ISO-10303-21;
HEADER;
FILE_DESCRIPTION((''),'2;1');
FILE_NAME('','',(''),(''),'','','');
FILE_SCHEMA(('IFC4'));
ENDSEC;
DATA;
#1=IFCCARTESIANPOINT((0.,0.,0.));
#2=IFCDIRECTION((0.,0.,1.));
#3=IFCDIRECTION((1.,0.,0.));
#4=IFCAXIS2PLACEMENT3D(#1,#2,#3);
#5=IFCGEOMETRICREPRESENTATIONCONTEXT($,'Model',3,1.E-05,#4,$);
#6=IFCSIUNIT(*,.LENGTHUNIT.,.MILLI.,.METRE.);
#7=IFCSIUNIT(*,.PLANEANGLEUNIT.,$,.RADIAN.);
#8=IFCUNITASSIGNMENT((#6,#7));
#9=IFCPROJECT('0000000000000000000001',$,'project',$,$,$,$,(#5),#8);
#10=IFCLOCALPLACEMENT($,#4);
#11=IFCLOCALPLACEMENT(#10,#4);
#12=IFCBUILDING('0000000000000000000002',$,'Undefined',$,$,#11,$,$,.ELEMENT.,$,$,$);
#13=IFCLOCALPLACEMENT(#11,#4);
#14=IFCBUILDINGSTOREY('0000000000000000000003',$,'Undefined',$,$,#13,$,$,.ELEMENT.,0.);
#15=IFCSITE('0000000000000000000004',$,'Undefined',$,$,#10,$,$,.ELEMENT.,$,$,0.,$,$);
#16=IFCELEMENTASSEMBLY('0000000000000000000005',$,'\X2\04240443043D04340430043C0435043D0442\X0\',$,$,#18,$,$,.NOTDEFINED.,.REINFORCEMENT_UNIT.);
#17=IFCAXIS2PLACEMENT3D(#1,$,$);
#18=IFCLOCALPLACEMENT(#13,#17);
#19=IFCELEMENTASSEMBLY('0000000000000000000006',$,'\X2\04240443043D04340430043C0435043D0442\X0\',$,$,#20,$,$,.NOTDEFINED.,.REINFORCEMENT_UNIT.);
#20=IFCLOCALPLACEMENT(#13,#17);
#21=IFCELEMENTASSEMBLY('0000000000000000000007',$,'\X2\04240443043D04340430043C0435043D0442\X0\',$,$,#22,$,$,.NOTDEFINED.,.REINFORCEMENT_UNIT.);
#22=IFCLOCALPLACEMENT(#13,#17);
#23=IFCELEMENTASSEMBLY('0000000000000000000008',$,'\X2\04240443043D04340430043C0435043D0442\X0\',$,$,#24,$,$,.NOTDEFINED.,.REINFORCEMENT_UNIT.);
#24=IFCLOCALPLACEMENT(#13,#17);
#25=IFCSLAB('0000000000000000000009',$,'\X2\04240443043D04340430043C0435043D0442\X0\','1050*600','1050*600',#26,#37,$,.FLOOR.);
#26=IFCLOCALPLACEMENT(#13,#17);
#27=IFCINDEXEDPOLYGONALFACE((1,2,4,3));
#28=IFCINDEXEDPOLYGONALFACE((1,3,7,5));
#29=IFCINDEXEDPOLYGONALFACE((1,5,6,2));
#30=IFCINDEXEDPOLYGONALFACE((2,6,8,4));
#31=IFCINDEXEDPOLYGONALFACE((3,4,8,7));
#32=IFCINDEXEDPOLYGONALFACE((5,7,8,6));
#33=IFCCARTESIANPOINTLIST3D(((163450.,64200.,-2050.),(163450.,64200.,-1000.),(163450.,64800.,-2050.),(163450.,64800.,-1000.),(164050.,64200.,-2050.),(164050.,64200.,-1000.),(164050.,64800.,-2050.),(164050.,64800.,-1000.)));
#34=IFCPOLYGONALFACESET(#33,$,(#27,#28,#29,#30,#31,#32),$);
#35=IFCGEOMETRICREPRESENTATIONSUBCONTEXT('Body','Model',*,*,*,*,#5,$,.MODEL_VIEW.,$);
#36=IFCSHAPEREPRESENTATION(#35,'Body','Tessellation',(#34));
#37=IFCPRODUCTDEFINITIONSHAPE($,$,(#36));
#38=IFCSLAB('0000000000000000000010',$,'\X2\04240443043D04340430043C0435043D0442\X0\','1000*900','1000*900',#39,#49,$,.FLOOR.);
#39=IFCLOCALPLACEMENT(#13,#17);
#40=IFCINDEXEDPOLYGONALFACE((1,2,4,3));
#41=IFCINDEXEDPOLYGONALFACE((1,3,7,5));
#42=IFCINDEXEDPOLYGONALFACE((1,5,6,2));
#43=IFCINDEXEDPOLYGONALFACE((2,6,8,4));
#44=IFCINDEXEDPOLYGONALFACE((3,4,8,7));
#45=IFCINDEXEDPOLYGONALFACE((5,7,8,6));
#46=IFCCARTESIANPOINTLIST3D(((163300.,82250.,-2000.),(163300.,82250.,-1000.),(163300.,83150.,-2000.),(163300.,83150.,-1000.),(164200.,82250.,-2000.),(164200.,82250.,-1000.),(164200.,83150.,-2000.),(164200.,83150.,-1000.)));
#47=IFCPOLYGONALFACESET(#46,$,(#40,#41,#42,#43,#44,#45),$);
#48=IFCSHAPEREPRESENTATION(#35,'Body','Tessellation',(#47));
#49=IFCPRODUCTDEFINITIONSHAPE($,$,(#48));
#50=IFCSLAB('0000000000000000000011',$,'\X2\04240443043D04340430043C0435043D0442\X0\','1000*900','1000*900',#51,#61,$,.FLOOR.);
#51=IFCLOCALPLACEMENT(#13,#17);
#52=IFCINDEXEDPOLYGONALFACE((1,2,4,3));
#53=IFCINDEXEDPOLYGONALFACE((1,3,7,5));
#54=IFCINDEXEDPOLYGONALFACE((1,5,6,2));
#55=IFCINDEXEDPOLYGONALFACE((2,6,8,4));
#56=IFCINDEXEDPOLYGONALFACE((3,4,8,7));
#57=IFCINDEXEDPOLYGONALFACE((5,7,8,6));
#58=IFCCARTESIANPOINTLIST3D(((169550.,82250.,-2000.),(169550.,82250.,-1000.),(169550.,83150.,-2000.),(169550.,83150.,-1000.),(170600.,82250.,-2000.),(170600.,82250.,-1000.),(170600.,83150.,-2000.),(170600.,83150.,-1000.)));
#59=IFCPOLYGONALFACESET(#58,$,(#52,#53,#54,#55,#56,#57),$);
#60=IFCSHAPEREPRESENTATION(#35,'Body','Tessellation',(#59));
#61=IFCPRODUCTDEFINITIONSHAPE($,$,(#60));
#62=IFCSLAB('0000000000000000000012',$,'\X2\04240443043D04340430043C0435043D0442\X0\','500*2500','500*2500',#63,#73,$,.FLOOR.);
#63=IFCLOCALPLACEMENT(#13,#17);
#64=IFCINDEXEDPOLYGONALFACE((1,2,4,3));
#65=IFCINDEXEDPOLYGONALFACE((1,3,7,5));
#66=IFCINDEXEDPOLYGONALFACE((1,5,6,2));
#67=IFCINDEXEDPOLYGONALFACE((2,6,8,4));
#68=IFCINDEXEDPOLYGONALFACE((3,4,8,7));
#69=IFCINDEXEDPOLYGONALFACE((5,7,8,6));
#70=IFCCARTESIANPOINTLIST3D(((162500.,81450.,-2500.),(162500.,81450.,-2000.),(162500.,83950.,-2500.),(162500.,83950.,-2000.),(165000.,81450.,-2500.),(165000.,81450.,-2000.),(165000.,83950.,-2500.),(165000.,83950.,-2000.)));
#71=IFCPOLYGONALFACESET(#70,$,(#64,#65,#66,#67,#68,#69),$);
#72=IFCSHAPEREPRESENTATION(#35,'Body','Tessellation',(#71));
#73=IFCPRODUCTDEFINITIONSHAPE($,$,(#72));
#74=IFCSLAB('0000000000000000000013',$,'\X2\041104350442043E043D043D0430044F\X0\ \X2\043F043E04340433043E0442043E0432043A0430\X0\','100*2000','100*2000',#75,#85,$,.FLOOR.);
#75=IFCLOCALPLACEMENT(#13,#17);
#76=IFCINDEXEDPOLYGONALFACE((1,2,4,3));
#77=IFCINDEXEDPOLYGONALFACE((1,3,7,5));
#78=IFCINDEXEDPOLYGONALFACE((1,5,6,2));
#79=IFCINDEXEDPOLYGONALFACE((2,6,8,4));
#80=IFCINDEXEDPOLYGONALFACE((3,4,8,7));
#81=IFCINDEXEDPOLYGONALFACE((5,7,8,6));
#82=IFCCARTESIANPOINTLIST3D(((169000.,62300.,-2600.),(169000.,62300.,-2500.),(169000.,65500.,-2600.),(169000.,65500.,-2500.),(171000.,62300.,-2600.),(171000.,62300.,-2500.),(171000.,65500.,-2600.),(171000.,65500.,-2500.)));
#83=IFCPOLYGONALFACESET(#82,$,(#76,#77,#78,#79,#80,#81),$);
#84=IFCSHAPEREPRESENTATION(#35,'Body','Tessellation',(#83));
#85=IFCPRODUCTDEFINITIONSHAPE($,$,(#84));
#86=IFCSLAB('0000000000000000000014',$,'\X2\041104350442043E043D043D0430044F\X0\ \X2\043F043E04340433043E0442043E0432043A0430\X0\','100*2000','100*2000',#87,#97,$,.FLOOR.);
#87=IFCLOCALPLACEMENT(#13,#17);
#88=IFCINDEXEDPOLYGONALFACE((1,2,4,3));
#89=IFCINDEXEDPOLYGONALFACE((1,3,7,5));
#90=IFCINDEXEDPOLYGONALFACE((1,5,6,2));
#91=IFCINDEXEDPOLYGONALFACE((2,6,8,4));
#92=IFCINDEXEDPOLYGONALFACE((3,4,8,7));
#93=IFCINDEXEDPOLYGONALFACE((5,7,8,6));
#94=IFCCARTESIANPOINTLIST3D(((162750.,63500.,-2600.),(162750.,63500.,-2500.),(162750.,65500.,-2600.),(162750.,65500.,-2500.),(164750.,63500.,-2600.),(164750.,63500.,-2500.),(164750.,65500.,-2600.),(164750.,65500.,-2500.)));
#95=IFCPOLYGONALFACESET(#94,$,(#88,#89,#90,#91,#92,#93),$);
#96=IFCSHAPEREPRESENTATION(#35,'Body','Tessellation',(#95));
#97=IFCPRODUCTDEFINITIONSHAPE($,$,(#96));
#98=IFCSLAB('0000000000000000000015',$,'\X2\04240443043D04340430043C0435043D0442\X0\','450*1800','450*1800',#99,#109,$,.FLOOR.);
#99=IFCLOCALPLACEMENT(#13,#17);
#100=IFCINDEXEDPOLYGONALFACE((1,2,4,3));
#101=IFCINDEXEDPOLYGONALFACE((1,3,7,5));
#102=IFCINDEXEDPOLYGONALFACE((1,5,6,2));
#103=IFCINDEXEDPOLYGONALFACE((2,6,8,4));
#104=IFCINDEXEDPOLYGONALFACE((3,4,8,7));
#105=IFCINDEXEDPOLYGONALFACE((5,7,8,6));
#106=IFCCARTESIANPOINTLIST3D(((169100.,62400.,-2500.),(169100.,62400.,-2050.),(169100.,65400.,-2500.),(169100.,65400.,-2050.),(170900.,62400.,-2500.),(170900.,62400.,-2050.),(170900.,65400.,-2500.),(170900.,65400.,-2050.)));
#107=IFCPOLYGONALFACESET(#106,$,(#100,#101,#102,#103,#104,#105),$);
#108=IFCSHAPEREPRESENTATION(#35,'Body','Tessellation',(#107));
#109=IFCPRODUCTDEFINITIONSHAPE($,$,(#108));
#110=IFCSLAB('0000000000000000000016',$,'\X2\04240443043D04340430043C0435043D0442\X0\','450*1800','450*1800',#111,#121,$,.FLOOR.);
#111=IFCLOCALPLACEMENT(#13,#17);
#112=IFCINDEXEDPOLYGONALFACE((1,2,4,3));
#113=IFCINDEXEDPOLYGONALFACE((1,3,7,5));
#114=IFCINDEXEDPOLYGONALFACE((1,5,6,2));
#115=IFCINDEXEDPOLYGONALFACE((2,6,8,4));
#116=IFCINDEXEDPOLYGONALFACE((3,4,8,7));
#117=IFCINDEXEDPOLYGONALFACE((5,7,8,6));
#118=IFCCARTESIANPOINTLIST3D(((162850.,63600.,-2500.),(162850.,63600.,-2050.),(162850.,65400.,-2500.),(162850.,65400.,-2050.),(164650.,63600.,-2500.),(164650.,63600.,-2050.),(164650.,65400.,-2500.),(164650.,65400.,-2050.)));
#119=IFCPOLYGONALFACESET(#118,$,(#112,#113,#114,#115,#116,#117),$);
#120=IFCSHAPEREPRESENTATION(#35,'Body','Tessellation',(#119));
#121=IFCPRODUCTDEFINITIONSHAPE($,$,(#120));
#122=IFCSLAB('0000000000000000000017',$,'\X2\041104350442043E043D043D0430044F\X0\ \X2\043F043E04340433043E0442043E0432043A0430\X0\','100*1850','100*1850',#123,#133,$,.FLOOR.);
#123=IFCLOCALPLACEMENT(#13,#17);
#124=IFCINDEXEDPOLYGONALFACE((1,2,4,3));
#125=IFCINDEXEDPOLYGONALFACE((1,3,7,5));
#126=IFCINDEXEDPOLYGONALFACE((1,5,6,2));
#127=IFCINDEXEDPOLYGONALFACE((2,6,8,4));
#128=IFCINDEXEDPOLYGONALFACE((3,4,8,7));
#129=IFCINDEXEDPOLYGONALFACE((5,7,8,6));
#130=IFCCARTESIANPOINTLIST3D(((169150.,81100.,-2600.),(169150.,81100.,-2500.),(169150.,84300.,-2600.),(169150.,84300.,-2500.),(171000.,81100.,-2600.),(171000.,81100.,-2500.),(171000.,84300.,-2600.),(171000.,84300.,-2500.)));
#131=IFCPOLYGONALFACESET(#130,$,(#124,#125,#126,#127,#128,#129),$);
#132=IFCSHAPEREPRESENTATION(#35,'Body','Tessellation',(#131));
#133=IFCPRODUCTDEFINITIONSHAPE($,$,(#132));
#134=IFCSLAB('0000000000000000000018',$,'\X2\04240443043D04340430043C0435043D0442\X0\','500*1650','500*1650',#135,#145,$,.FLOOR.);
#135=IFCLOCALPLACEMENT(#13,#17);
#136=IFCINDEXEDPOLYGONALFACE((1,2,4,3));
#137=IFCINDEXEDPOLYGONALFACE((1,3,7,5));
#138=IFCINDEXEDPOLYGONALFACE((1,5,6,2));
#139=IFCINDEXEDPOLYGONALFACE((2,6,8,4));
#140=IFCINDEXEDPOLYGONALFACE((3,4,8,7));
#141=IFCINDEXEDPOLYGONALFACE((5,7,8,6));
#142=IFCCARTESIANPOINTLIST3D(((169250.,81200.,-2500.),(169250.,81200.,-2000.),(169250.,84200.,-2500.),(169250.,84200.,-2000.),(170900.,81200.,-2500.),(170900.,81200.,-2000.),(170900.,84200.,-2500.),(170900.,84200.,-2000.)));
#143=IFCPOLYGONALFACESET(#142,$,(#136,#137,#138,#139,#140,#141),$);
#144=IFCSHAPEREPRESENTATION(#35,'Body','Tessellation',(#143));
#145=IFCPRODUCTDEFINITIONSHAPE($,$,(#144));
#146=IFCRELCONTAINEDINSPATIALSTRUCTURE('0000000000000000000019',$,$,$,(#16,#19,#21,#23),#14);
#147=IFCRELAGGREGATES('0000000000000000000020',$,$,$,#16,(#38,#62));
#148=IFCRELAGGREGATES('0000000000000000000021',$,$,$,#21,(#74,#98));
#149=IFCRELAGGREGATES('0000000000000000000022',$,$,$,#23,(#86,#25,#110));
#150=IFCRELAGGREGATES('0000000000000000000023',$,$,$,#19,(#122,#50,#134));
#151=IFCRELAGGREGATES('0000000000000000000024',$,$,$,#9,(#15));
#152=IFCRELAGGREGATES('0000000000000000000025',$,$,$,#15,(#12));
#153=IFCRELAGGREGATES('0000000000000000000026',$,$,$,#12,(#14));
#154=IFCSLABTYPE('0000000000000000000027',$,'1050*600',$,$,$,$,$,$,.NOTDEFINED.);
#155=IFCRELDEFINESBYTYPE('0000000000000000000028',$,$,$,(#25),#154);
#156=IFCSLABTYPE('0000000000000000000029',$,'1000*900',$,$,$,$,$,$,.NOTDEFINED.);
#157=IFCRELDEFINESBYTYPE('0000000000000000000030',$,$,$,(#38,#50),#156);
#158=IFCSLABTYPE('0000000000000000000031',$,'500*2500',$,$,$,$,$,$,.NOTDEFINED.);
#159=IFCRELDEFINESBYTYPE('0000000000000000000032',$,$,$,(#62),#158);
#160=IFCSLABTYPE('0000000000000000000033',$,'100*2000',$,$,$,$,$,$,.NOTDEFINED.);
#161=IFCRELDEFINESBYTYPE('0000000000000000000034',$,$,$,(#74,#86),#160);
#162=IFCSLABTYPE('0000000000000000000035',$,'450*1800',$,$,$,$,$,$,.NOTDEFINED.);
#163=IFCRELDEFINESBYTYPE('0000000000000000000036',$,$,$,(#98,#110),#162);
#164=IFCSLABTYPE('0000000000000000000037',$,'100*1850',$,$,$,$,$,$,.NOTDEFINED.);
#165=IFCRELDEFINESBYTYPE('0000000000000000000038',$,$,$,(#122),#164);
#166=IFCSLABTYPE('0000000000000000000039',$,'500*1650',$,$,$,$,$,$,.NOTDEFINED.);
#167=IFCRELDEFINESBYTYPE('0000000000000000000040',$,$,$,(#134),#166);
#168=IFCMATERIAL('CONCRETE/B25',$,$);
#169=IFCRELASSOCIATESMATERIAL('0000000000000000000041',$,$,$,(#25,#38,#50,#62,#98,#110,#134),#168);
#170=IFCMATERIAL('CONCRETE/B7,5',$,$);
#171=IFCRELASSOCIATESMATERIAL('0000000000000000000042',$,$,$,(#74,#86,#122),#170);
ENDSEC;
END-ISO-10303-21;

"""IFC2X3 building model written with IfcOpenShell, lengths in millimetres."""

from ifc_helpers import new_model, si_unit, frame, origin_with_axes, place, context, subcontext, project, spatial, polyline, outline, extrude, material, type_object, element, aggregate, save


model = new_model("IFC2X3")

# Units and contexts
model_context = context("Model", 3, precision=1e-05, world=origin_with_axes())
body_context = subcontext(model_context, "Body", "Model", "MODEL_VIEW")
ifc_project = project(units=[si_unit("LENGTHUNIT", "METRE", prefix="MILLI"), si_unit("PLANEANGLEUNIT", "RADIAN")], contexts=[model_context])

# Site, building, storey
site_placement = place(None, origin_with_axes())
site = spatial("IfcSite", under=ifc_project, at=site_placement, Name="Undefined", CompositionType="ELEMENT", RefElevation=0.0)
building_placement = place(site_placement, origin_with_axes())
building = spatial("IfcBuilding", under=site, at=building_placement, Name="Undefined", CompositionType="ELEMENT")
storey_placement = place(building_placement, origin_with_axes())
storey = spatial("IfcBuildingStorey", under=building, at=storey_placement, Name="Undefined", CompositionType="ELEMENT", Elevation=0.0)

# Element assemblies
assembly_1_placement = place(storey_placement, origin_with_axes())
assembly_1 = element("IfcElementAssembly", 1, at=assembly_1_placement, inside=storey, Name="Фундамент", AssemblyPlace="NOTDEFINED", PredefinedType="REINFORCEMENT_UNIT")
ifc_material_1 = material(Name="CONCRETE/B25")
assembly_2_placement = place(storey_placement, origin_with_axes())
assembly_2 = element("IfcElementAssembly", 2, at=assembly_2_placement, inside=storey, Name="Фундамент", AssemblyPlace="NOTDEFINED", PredefinedType="REINFORCEMENT_UNIT")

# Shared definitions
ifc_material_2 = material(Name="CONCRETE/B7,5")

# Element assemblies, slab
assembly_3_placement = place(storey_placement, origin_with_axes())
assembly_3 = element("IfcElementAssembly", 3, at=assembly_3_placement, inside=storey, Name="Фундамент", AssemblyPlace="NOTDEFINED", PredefinedType="REINFORCEMENT_UNIT")
slab_type_1 = type_object("IfcSlabType", Name="1050*600", PredefinedType="NOTDEFINED")
assembly_4_placement = place(storey_placement, origin_with_axes())
assembly_4 = element("IfcElementAssembly", 4, at=assembly_4_placement, inside=storey, Name="Фундамент", AssemblyPlace="NOTDEFINED", PredefinedType="REINFORCEMENT_UNIT")
slab_1_placement = place(assembly_4_placement, frame((163450.0, 64800.0, -1525.0), z_axis=(0.0, 0.0, 1.0), x_axis=(0.0, -1.0, 0.0)))
slab_1 = element("IfcSlab", 5, at=slab_1_placement, type_object=slab_type_1, material=ifc_material_1, Name="Фундамент", Description="1050*600", ObjectType="1050*600", PredefinedType="FLOOR", context=body_context, shape_type="SweptSolid", body=[
    extrude(outline(polyline([(0.0, 0.0), (600.0, 0.0), (600.0, 600.0), (0.0, 600.0), (0.0, 0.0)])), frame((0.0, 0.0, -525.0), z_axis=(0.0, 0.0, 1.0), x_axis=(1.0, 0.0, 0.0)), (0.0, 0.0, 1.0), 1050.0),
])

# Slabs
slab_type_2 = type_object("IfcSlabType", Name="1000*900", PredefinedType="NOTDEFINED")
slab_2_placement = place(assembly_1_placement, frame((163300.0, 83150.0, -1500.0), z_axis=(0.0, 0.0, 1.0), x_axis=(0.0, -1.0, 0.0)))
slab_2 = element("IfcSlab", 6, at=slab_2_placement, type_object=slab_type_2, material=ifc_material_1, Name="Фундамент", Description="1000*900", ObjectType="1000*900", PredefinedType="FLOOR", context=body_context, shape_type="SweptSolid", body=[
    extrude(outline(polyline([(0.0, 0.0), (900.0, 0.0), (900.0, 900.0), (0.0, 900.0), (0.0, 0.0)])), frame((0.0, 0.0, -500.0), z_axis=(0.0, 0.0, 1.0), x_axis=(1.0, 0.0, 0.0)), (0.0, 0.0, 1.0), 1000.0),
])
slab_3_placement = place(assembly_2_placement, frame((169550.0, 83150.0, -1500.0), z_axis=(0.0, 0.0, 1.0), x_axis=(0.0, -1.0, 0.0)))
slab_3 = element("IfcSlab", 7, at=slab_3_placement, type_object=slab_type_2, material=ifc_material_1, Name="Фундамент", Description="1000*900", ObjectType="1000*900", PredefinedType="FLOOR", context=body_context, shape_type="SweptSolid", body=[
    extrude(outline(polyline([(0.0, 0.0), (900.0, 0.0), (900.0, 1050.0), (0.0, 1050.0), (0.0, 0.0)])), frame((0.0, 0.0, -500.0), z_axis=(0.0, 0.0, 1.0), x_axis=(1.0, 0.0, 0.0)), (0.0, 0.0, 1.0), 1000.0),
])
slab_type_3 = type_object("IfcSlabType", Name="500*2500", PredefinedType="NOTDEFINED")
slab_4_placement = place(assembly_1_placement, frame((162500.0, 83950.0, -2250.0), z_axis=(0.0, 0.0, 1.0), x_axis=(0.0, -1.0, 0.0)))
slab_4 = element("IfcSlab", 8, at=slab_4_placement, type_object=slab_type_3, material=ifc_material_1, Name="Фундамент", Description="500*2500", ObjectType="500*2500", PredefinedType="FLOOR", context=body_context, shape_type="SweptSolid", body=[
    extrude(outline(polyline([(0.0, 0.0), (2500.0, 0.0), (2500.0, 2500.0), (0.0, 2500.0), (0.0, 0.0)])), frame((0.0, 0.0, -250.0), z_axis=(0.0, 0.0, 1.0), x_axis=(1.0, 0.0, 0.0)), (0.0, 0.0, 1.0), 500.0),
])
aggregate(assembly_1, [slab_2, slab_4])
slab_type_4 = type_object("IfcSlabType", Name="100*2000", PredefinedType="NOTDEFINED")
slab_5_placement = place(assembly_3_placement, frame((169000.0, 65500.0, -2550.0), z_axis=(0.0, 0.0, 1.0), x_axis=(0.0, -1.0, 0.0)))
slab_5 = element("IfcSlab", 9, at=slab_5_placement, type_object=slab_type_4, material=ifc_material_2, Name="Бетонная подготовка", Description="100*2000", ObjectType="100*2000", PredefinedType="FLOOR", context=body_context, shape_type="SweptSolid", body=[
    extrude(outline(polyline([(0.0, 0.0), (3200.0, 0.0), (3200.0, 2000.0), (0.0, 2000.0), (0.0, 0.0)])), frame((0.0, 0.0, -50.0), z_axis=(0.0, 0.0, 1.0), x_axis=(1.0, 0.0, 0.0)), (0.0, 0.0, 1.0), 100.0),
])
slab_6_placement = place(assembly_4_placement, frame((162750.0, 65500.0, -2550.0), z_axis=(0.0, 0.0, 1.0), x_axis=(0.0, -1.0, 0.0)))
slab_6 = element("IfcSlab", 10, at=slab_6_placement, type_object=slab_type_4, material=ifc_material_2, Name="Бетонная подготовка", Description="100*2000", ObjectType="100*2000", PredefinedType="FLOOR", context=body_context, shape_type="SweptSolid", body=[
    extrude(outline(polyline([(0.0, 0.0), (2000.0, 0.0), (2000.0, 2000.0), (0.0, 2000.0), (0.0, 0.0)])), frame((0.0, 0.0, -50.0), z_axis=(0.0, 0.0, 1.0), x_axis=(1.0, 0.0, 0.0)), (0.0, 0.0, 1.0), 100.0),
])
slab_type_5 = type_object("IfcSlabType", Name="450*1800", PredefinedType="NOTDEFINED")
slab_7_placement = place(assembly_3_placement, frame((169100.0, 65400.0, -2275.0), z_axis=(0.0, 0.0, 1.0), x_axis=(0.0, -1.0, 0.0)))
slab_7 = element("IfcSlab", 11, at=slab_7_placement, type_object=slab_type_5, material=ifc_material_1, Name="Фундамент", Description="450*1800", ObjectType="450*1800", PredefinedType="FLOOR", context=body_context, shape_type="SweptSolid", body=[
    extrude(outline(polyline([(0.0, 0.0), (3000.0, 0.0), (3000.0, 1800.0), (0.0, 1800.0), (0.0, 0.0)])), frame((0.0, 0.0, -225.0), z_axis=(0.0, 0.0, 1.0), x_axis=(1.0, 0.0, 0.0)), (0.0, 0.0, 1.0), 450.0),
])
aggregate(assembly_3, [slab_5, slab_7])
slab_8_placement = place(assembly_4_placement, frame((162850.0, 65400.0, -2275.0), z_axis=(0.0, 0.0, 1.0), x_axis=(0.0, -1.0, 0.0)))
slab_8 = element("IfcSlab", 12, at=slab_8_placement, type_object=slab_type_5, material=ifc_material_1, Name="Фундамент", Description="450*1800", ObjectType="450*1800", PredefinedType="FLOOR", context=body_context, shape_type="SweptSolid", body=[
    extrude(outline(polyline([(0.0, 0.0), (1800.0, 0.0), (1800.0, 1800.0), (0.0, 1800.0), (0.0, 0.0)])), frame((0.0, 0.0, -225.0), z_axis=(0.0, 0.0, 1.0), x_axis=(1.0, 0.0, 0.0)), (0.0, 0.0, 1.0), 450.0),
])
aggregate(assembly_4, [slab_6, slab_1, slab_8])
slab_type_6 = type_object("IfcSlabType", Name="100*1850", PredefinedType="NOTDEFINED")
slab_9_placement = place(assembly_2_placement, frame((169150.0, 84300.0, -2550.0), z_axis=(0.0, 0.0, 1.0), x_axis=(0.0, -1.0, 0.0)))
slab_9 = element("IfcSlab", 13, at=slab_9_placement, type_object=slab_type_6, material=ifc_material_2, Name="Бетонная подготовка", Description="100*1850", ObjectType="100*1850", PredefinedType="FLOOR", context=body_context, shape_type="SweptSolid", body=[
    extrude(outline(polyline([(0.0, 0.0), (3200.0, 0.0), (3200.0, 1850.0), (0.0, 1850.0), (0.0, 0.0)])), frame((0.0, 0.0, -50.0), z_axis=(0.0, 0.0, 1.0), x_axis=(1.0, 0.0, 0.0)), (0.0, 0.0, 1.0), 100.0),
])
slab_type_7 = type_object("IfcSlabType", Name="500*1650", PredefinedType="NOTDEFINED")
slab_10_placement = place(assembly_2_placement, frame((169250.0, 84200.0, -2250.0), z_axis=(0.0, 0.0, 1.0), x_axis=(0.0, -1.0, 0.0)))
slab_10 = element("IfcSlab", 14, at=slab_10_placement, type_object=slab_type_7, material=ifc_material_1, Name="Фундамент", Description="500*1650", ObjectType="500*1650", PredefinedType="FLOOR", context=body_context, shape_type="SweptSolid", body=[
    extrude(outline(polyline([(0.0, 0.0), (3000.0, 0.0), (3000.0, 1650.0), (0.0, 1650.0), (0.0, 0.0)])), frame((0.0, 0.0, -250.0), z_axis=(0.0, 0.0, 1.0), x_axis=(1.0, 0.0, 0.0)), (0.0, 0.0, 1.0), 500.0),
])
aggregate(assembly_2, [slab_9, slab_3, slab_10])

save(model, "model.ifc")
